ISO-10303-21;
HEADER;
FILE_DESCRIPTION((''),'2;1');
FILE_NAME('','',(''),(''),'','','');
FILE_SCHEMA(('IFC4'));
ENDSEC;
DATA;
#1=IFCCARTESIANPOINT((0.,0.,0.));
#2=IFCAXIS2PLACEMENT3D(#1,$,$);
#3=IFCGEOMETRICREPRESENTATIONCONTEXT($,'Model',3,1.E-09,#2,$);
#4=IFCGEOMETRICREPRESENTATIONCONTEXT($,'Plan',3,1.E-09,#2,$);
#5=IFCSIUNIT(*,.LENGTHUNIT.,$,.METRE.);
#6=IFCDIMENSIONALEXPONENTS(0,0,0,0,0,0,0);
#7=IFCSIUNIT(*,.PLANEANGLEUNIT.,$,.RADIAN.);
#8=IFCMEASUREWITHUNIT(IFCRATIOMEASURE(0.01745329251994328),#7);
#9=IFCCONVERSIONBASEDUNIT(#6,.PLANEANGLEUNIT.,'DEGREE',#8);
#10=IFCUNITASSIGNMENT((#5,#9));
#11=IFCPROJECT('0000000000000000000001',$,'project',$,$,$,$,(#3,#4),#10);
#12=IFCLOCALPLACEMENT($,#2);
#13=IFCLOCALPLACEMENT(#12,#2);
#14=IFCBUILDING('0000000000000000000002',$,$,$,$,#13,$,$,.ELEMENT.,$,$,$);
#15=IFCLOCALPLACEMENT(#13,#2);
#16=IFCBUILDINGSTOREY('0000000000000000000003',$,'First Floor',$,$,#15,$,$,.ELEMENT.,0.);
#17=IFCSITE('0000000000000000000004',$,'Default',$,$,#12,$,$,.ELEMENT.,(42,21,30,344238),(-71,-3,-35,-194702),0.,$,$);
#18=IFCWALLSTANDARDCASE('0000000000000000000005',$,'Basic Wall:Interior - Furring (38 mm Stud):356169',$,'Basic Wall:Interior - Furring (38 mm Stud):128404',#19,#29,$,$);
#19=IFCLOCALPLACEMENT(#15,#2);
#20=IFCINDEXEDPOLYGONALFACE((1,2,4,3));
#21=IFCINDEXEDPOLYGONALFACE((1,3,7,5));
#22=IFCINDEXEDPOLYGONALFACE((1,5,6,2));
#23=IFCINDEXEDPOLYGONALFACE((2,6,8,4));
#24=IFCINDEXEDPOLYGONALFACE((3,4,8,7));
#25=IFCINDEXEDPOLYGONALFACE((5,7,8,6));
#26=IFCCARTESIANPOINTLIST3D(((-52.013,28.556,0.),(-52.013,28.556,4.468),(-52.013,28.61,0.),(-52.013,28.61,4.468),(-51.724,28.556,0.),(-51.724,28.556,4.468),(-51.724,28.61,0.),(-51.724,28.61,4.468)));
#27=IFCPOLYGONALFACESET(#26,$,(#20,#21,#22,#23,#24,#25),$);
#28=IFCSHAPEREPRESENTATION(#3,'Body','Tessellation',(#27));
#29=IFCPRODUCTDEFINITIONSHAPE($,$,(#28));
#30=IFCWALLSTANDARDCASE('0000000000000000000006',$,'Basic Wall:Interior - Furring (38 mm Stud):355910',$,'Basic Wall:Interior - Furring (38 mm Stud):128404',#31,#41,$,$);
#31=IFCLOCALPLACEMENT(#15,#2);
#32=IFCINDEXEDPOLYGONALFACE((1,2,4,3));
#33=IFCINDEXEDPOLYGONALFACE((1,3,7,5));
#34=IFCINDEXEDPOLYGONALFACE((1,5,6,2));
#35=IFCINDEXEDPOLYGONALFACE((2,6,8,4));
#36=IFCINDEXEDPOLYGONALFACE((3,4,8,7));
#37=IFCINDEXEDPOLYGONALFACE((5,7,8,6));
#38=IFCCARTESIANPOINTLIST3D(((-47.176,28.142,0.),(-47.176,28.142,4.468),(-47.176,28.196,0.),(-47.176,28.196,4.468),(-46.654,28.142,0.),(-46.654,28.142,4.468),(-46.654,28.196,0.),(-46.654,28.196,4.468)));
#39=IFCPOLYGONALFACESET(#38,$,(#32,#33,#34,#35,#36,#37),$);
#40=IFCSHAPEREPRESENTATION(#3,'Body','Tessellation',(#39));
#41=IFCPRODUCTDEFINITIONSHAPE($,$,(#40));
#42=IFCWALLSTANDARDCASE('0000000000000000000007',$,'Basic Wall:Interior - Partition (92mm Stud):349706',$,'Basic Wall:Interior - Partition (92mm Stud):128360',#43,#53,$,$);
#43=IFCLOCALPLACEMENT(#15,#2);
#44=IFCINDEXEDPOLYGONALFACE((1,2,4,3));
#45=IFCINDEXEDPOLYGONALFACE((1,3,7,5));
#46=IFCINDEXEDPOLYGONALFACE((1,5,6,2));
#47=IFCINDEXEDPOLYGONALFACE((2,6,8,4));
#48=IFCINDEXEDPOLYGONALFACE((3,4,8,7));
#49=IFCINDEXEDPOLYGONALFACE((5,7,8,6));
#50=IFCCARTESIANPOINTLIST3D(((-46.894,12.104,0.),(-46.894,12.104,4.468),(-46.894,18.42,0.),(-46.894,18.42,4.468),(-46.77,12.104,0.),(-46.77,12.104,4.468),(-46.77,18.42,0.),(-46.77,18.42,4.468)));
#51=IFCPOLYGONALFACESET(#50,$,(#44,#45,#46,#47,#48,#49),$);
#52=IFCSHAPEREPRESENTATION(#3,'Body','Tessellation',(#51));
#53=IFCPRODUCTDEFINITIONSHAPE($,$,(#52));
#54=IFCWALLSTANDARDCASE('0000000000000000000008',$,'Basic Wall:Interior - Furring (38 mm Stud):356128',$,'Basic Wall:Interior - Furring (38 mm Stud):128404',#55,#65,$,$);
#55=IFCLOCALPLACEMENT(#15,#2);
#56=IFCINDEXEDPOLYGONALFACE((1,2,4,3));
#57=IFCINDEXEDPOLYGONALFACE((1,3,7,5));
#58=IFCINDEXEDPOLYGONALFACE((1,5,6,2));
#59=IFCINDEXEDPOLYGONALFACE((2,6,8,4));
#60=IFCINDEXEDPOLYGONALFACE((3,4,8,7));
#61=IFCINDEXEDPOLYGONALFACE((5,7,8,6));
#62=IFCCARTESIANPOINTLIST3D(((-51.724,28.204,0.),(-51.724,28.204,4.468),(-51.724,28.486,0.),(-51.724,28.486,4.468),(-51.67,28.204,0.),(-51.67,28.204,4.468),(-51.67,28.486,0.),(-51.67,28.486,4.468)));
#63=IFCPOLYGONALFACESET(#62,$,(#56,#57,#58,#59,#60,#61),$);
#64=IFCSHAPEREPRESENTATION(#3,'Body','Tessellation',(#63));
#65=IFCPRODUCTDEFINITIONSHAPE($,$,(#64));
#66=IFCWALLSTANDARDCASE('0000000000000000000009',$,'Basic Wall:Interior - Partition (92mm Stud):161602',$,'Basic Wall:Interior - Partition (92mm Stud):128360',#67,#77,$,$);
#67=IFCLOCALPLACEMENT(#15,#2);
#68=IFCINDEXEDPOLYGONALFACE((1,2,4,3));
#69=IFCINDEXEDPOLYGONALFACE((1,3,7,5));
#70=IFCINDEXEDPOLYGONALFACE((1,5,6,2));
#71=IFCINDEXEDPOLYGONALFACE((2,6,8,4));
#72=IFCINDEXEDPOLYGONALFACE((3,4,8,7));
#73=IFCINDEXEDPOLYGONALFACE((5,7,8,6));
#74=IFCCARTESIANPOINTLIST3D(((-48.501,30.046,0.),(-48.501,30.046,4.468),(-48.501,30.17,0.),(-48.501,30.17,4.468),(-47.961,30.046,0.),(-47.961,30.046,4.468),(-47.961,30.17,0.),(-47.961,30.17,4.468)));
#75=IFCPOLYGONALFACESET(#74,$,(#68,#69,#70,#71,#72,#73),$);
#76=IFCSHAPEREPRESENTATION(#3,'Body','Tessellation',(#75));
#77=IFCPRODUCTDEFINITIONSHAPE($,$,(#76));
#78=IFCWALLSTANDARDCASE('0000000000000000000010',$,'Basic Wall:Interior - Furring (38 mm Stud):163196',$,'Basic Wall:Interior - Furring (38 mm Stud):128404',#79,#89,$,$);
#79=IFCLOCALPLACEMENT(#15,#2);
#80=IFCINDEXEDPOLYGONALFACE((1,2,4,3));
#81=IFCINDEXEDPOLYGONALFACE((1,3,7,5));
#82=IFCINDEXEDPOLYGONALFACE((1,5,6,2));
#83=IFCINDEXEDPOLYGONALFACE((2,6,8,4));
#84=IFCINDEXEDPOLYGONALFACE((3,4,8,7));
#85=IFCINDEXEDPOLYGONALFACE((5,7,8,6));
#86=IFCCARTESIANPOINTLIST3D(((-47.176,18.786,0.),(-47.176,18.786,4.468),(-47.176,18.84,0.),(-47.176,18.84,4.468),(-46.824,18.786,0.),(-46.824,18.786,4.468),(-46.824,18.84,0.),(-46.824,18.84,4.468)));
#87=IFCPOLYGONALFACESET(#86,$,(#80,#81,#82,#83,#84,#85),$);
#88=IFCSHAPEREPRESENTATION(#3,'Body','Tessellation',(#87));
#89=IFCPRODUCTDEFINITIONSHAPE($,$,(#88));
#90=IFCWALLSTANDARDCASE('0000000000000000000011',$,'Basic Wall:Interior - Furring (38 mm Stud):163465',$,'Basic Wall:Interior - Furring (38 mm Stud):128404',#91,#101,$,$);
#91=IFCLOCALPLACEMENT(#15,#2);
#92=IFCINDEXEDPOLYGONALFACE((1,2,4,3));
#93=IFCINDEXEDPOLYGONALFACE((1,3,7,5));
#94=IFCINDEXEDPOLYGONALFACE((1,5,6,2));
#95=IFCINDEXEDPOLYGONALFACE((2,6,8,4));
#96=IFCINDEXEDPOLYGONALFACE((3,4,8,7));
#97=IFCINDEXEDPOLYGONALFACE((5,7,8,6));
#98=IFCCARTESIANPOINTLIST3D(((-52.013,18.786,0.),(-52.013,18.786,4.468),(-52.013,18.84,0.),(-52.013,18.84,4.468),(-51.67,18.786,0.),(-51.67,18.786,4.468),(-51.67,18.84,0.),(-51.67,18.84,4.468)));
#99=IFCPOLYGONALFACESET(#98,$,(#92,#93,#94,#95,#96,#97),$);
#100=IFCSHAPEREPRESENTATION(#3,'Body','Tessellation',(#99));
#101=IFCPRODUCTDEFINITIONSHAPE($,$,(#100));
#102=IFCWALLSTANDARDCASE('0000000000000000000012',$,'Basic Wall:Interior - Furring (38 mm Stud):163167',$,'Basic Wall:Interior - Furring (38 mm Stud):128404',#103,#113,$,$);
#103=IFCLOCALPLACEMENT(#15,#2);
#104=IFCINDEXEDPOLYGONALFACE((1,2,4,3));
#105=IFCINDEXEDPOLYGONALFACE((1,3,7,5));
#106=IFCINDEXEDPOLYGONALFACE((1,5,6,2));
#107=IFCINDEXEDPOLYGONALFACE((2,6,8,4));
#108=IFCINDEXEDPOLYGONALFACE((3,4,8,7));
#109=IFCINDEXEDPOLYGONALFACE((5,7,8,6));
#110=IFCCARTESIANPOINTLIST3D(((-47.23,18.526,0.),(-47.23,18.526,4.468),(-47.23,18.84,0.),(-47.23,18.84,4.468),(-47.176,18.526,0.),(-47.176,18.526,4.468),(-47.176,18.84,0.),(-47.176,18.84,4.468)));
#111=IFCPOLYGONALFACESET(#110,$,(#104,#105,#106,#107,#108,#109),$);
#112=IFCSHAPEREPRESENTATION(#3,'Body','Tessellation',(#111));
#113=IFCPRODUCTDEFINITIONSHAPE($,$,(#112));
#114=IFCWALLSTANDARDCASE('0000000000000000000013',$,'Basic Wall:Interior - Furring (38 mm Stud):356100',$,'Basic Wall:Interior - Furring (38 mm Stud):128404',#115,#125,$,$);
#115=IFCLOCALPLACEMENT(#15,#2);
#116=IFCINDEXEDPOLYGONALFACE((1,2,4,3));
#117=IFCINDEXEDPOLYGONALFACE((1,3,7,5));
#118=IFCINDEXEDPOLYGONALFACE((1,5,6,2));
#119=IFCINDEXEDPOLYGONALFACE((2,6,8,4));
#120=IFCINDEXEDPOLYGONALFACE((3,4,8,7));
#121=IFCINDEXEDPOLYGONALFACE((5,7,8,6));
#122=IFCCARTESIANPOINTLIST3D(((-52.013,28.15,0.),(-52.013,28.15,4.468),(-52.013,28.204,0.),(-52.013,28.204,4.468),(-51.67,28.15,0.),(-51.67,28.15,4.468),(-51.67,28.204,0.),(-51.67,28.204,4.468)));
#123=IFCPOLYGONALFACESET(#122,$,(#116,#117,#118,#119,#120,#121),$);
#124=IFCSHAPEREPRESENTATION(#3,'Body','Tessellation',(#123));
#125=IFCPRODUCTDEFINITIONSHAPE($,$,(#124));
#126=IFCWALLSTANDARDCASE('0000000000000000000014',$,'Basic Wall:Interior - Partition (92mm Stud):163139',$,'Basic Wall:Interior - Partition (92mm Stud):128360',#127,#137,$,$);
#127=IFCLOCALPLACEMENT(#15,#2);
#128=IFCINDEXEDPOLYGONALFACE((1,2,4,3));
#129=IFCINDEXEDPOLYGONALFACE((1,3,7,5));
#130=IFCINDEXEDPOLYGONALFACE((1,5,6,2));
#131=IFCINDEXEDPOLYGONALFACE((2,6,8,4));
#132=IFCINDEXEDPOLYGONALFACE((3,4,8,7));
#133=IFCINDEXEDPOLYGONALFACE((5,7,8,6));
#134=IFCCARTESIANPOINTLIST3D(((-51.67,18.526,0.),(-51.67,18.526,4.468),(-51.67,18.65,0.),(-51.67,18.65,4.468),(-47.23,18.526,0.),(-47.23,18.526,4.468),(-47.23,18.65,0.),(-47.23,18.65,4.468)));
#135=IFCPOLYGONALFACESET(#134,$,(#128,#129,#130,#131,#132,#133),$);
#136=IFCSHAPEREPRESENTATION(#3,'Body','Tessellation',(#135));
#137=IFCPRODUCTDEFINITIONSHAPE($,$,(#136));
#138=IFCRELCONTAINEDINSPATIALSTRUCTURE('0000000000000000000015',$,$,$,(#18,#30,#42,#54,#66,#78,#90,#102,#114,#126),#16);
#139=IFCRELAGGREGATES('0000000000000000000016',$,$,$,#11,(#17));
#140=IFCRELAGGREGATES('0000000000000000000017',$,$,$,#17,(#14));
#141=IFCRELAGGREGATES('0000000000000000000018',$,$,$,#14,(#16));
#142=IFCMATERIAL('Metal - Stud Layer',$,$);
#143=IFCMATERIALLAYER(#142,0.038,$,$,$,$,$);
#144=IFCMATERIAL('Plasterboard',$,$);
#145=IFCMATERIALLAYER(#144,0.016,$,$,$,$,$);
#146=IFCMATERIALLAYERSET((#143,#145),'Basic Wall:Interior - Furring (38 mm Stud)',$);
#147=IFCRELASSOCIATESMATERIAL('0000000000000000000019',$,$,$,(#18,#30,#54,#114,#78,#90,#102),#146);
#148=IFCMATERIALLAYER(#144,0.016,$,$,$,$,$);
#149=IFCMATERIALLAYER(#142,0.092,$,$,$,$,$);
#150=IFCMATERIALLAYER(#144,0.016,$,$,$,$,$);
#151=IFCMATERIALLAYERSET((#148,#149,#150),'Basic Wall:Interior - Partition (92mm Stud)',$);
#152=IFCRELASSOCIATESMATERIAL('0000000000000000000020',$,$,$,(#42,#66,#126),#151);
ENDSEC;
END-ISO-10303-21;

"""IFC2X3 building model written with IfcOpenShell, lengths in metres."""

from ifc_helpers import new_model, entity, si_unit, converted_unit, frame, frame_2d, origin, place, context, project, spatial, rectangle, extrude, material, layer, layer_set, layer_usage, element, save


model = new_model("IFC2X3")

# Units and contexts
model_context = context("Model", 3, precision=1e-09, world=origin())
plan_context = context("Plan", 3, precision=1e-09, world=origin())
ifc_project = project(units=[si_unit("LENGTHUNIT", "METRE"), converted_unit("PLANEANGLEUNIT", "DEGREE", entity("IfcRatioMeasure", 0.01745329251994328), si_unit("PLANEANGLEUNIT", "RADIAN"), dimensions=[0, 0, 0, 0, 0, 0, 0])], contexts=[model_context, plan_context])

# Site, building, storey
site_placement = place(None, origin())
site = spatial("IfcSite", under=ifc_project, at=site_placement, Name="Default", CompositionType="ELEMENT", RefLatitude=(42, 21, 30, 344238), RefLongitude=(-71, -3, -35, -194702), RefElevation=0.0)
building_placement = place(site_placement, origin())
building = spatial("IfcBuilding", under=site, at=building_placement, CompositionType="ELEMENT")
storey_placement = place(building_placement, origin())
storey = spatial("IfcBuildingStorey", under=building, at=storey_placement, Name="First Floor", CompositionType="ELEMENT", Elevation=0.0)

# Shared definitions
ifc_material_1 = material(Name="Plasterboard")
ifc_layer_1 = layer(ifc_material_1, 0.016)
ifc_material_2 = material(Name="Metal - Stud Layer")
ifc_layer_2 = layer(ifc_material_2, 0.092)
ifc_layer_3 = layer(ifc_material_1, 0.016)
ifc_layer_set_1 = layer_set([ifc_layer_1, ifc_layer_2, ifc_layer_3], Name="Basic Wall:Interior - Partition (92mm Stud)")
ifc_layer_usage_1 = layer_usage(ifc_layer_set_1, "AXIS2", "NEGATIVE", 0.062)

# Shared definitions
ifc_layer_4 = layer(ifc_material_2, 0.038)
ifc_layer_5 = layer(ifc_material_1, 0.016)
ifc_layer_set_2 = layer_set([ifc_layer_4, ifc_layer_5], Name="Basic Wall:Interior - Furring (38 mm Stud)")
ifc_layer_usage_2 = layer_usage(ifc_layer_set_2, "AXIS2", "POSITIVE", -0.027)
ifc_layer_usage_3 = layer_usage(ifc_layer_set_2, "AXIS2", "NEGATIVE", 0.027)

# Walls
wall_1_placement = place(storey_placement, frame((-51.724, 28.583, 0.0), z_axis=(0.0, 0.0, 1.0), x_axis=(-1.0, 0.0, 0.0)))
element("IfcWallStandardCase", 1, at=wall_1_placement, inside=storey, material=ifc_layer_usage_3, Name="Basic Wall:Interior - Furring (38 mm Stud):356169", ObjectType="Basic Wall:Interior - Furring (38 mm Stud):128404", context=model_context, shape_type="SweptSolid", body=[
    extrude(rectangle(XDim=0.289, YDim=0.054, at=frame_2d((0.1445, 0.0), x_axis=(-1.0, 0.0))), origin(), (0.0, 0.0, 1.0), 4.468),
])
wall_2_placement = place(storey_placement, frame((-47.176, 28.169, 0.0)))
element("IfcWallStandardCase", 2, at=wall_2_placement, inside=storey, material=ifc_layer_usage_3, Name="Basic Wall:Interior - Furring (38 mm Stud):355910", ObjectType="Basic Wall:Interior - Furring (38 mm Stud):128404", context=model_context, shape_type="SweptSolid", body=[
    extrude(rectangle(XDim=0.522, YDim=0.054, at=frame_2d((0.261, 0.0), x_axis=(-1.0, 0.0))), origin(), (0.0, 0.0, 1.0), 4.468),
])
wall_3_placement = place(storey_placement, frame((-46.832, 18.42, 0.0), z_axis=(0.0, 0.0, 1.0), x_axis=(0.0, -1.0, 0.0)))
element("IfcWallStandardCase", 3, at=wall_3_placement, inside=storey, material=ifc_layer_usage_1, Name="Basic Wall:Interior - Partition (92mm Stud):349706", ObjectType="Basic Wall:Interior - Partition (92mm Stud):128360", context=model_context, shape_type="SweptSolid", body=[
    extrude(rectangle(XDim=6.316, YDim=0.124, at=frame_2d((3.158, 0.0), x_axis=(-1.0, 0.0))), origin(), (0.0, 0.0, 1.0), 4.468),
])
wall_4_placement = place(storey_placement, frame((-51.697, 28.204, 0.0), z_axis=(0.0, 0.0, 1.0), x_axis=(0.0, 1.0, 0.0)))
element("IfcWallStandardCase", 4, at=wall_4_placement, inside=storey, material=ifc_layer_usage_3, Name="Basic Wall:Interior - Furring (38 mm Stud):356128", ObjectType="Basic Wall:Interior - Furring (38 mm Stud):128404", context=model_context, shape_type="SweptSolid", body=[
    extrude(rectangle(XDim=0.282, YDim=0.054, at=frame_2d((0.141, 0.0), x_axis=(-1.0, 0.0))), origin(), (0.0, 0.0, 1.0), 4.468),
])
wall_5_placement = place(storey_placement, frame((-48.501, 30.108, 0.0)))
element("IfcWallStandardCase", 5, at=wall_5_placement, inside=storey, material=ifc_layer_usage_1, Name="Basic Wall:Interior - Partition (92mm Stud):161602", ObjectType="Basic Wall:Interior - Partition (92mm Stud):128360", context=model_context, shape_type="SweptSolid", body=[
    extrude(rectangle(XDim=0.54, YDim=0.124, at=frame_2d((0.27, 0.0), x_axis=(-1.0, 0.0))), origin(), (0.0, 0.0, 1.0), 4.468),
])
wall_6_placement = place(storey_placement, frame((-47.176, 18.813, 0.0)))
element("IfcWallStandardCase", 6, at=wall_6_placement, inside=storey, material=ifc_layer_usage_2, Name="Basic Wall:Interior - Furring (38 mm Stud):163196", ObjectType="Basic Wall:Interior - Furring (38 mm Stud):128404", context=model_context, shape_type="SweptSolid", body=[
    extrude(rectangle(XDim=0.352, YDim=0.054, at=frame_2d((0.176, 0.0), x_axis=(-1.0, 0.0))), origin(), (0.0, 0.0, 1.0), 4.468),
])
wall_7_placement = place(storey_placement, frame((-52.013, 18.813, 0.0)))
element("IfcWallStandardCase", 7, at=wall_7_placement, inside=storey, material=ifc_layer_usage_2, Name="Basic Wall:Interior - Furring (38 mm Stud):163465", ObjectType="Basic Wall:Interior - Furring (38 mm Stud):128404", context=model_context, shape_type="SweptSolid", body=[
    extrude(rectangle(XDim=0.343, YDim=0.054, at=frame_2d((0.1715, 0.0), x_axis=(-1.0, 0.0))), origin(), (0.0, 0.0, 1.0), 4.468),
])
wall_8_placement = place(storey_placement, frame((-47.203, 18.526, 0.0), z_axis=(0.0, 0.0, 1.0), x_axis=(0.0, 1.0, 0.0)))
element("IfcWallStandardCase", 8, at=wall_8_placement, inside=storey, material=ifc_layer_usage_2, Name="Basic Wall:Interior - Furring (38 mm Stud):163167", ObjectType="Basic Wall:Interior - Furring (38 mm Stud):128404", context=model_context, shape_type="SweptSolid", body=[
    extrude(rectangle(XDim=0.314, YDim=0.054, at=frame_2d((0.157, 0.0), x_axis=(-1.0, 0.0))), origin(), (0.0, 0.0, 1.0), 4.468),
])
wall_9_placement = place(storey_placement, frame((-52.013, 28.177, 0.0)))
element("IfcWallStandardCase", 9, at=wall_9_placement, inside=storey, material=ifc_layer_usage_3, Name="Basic Wall:Interior - Furring (38 mm Stud):356100", ObjectType="Basic Wall:Interior - Furring (38 mm Stud):128404", context=model_context, shape_type="SweptSolid", body=[
    extrude(rectangle(XDim=0.343, YDim=0.054, at=frame_2d((0.1715, 0.0), x_axis=(-1.0, 0.0))), origin(), (0.0, 0.0, 1.0), 4.468),
])
wall_10_placement = place(storey_placement, frame((-51.67, 18.588, 0.0)))
element("IfcWallStandardCase", 10, at=wall_10_placement, inside=storey, material=ifc_layer_usage_1, Name="Basic Wall:Interior - Partition (92mm Stud):163139", ObjectType="Basic Wall:Interior - Partition (92mm Stud):128360", context=model_context, shape_type="SweptSolid", body=[
    extrude(rectangle(XDim=4.44, YDim=0.124, at=frame_2d((2.22, 0.0), x_axis=(-1.0, 0.0))), origin(), (0.0, 0.0, 1.0), 4.468),
])

save(model, "model.ifc")
